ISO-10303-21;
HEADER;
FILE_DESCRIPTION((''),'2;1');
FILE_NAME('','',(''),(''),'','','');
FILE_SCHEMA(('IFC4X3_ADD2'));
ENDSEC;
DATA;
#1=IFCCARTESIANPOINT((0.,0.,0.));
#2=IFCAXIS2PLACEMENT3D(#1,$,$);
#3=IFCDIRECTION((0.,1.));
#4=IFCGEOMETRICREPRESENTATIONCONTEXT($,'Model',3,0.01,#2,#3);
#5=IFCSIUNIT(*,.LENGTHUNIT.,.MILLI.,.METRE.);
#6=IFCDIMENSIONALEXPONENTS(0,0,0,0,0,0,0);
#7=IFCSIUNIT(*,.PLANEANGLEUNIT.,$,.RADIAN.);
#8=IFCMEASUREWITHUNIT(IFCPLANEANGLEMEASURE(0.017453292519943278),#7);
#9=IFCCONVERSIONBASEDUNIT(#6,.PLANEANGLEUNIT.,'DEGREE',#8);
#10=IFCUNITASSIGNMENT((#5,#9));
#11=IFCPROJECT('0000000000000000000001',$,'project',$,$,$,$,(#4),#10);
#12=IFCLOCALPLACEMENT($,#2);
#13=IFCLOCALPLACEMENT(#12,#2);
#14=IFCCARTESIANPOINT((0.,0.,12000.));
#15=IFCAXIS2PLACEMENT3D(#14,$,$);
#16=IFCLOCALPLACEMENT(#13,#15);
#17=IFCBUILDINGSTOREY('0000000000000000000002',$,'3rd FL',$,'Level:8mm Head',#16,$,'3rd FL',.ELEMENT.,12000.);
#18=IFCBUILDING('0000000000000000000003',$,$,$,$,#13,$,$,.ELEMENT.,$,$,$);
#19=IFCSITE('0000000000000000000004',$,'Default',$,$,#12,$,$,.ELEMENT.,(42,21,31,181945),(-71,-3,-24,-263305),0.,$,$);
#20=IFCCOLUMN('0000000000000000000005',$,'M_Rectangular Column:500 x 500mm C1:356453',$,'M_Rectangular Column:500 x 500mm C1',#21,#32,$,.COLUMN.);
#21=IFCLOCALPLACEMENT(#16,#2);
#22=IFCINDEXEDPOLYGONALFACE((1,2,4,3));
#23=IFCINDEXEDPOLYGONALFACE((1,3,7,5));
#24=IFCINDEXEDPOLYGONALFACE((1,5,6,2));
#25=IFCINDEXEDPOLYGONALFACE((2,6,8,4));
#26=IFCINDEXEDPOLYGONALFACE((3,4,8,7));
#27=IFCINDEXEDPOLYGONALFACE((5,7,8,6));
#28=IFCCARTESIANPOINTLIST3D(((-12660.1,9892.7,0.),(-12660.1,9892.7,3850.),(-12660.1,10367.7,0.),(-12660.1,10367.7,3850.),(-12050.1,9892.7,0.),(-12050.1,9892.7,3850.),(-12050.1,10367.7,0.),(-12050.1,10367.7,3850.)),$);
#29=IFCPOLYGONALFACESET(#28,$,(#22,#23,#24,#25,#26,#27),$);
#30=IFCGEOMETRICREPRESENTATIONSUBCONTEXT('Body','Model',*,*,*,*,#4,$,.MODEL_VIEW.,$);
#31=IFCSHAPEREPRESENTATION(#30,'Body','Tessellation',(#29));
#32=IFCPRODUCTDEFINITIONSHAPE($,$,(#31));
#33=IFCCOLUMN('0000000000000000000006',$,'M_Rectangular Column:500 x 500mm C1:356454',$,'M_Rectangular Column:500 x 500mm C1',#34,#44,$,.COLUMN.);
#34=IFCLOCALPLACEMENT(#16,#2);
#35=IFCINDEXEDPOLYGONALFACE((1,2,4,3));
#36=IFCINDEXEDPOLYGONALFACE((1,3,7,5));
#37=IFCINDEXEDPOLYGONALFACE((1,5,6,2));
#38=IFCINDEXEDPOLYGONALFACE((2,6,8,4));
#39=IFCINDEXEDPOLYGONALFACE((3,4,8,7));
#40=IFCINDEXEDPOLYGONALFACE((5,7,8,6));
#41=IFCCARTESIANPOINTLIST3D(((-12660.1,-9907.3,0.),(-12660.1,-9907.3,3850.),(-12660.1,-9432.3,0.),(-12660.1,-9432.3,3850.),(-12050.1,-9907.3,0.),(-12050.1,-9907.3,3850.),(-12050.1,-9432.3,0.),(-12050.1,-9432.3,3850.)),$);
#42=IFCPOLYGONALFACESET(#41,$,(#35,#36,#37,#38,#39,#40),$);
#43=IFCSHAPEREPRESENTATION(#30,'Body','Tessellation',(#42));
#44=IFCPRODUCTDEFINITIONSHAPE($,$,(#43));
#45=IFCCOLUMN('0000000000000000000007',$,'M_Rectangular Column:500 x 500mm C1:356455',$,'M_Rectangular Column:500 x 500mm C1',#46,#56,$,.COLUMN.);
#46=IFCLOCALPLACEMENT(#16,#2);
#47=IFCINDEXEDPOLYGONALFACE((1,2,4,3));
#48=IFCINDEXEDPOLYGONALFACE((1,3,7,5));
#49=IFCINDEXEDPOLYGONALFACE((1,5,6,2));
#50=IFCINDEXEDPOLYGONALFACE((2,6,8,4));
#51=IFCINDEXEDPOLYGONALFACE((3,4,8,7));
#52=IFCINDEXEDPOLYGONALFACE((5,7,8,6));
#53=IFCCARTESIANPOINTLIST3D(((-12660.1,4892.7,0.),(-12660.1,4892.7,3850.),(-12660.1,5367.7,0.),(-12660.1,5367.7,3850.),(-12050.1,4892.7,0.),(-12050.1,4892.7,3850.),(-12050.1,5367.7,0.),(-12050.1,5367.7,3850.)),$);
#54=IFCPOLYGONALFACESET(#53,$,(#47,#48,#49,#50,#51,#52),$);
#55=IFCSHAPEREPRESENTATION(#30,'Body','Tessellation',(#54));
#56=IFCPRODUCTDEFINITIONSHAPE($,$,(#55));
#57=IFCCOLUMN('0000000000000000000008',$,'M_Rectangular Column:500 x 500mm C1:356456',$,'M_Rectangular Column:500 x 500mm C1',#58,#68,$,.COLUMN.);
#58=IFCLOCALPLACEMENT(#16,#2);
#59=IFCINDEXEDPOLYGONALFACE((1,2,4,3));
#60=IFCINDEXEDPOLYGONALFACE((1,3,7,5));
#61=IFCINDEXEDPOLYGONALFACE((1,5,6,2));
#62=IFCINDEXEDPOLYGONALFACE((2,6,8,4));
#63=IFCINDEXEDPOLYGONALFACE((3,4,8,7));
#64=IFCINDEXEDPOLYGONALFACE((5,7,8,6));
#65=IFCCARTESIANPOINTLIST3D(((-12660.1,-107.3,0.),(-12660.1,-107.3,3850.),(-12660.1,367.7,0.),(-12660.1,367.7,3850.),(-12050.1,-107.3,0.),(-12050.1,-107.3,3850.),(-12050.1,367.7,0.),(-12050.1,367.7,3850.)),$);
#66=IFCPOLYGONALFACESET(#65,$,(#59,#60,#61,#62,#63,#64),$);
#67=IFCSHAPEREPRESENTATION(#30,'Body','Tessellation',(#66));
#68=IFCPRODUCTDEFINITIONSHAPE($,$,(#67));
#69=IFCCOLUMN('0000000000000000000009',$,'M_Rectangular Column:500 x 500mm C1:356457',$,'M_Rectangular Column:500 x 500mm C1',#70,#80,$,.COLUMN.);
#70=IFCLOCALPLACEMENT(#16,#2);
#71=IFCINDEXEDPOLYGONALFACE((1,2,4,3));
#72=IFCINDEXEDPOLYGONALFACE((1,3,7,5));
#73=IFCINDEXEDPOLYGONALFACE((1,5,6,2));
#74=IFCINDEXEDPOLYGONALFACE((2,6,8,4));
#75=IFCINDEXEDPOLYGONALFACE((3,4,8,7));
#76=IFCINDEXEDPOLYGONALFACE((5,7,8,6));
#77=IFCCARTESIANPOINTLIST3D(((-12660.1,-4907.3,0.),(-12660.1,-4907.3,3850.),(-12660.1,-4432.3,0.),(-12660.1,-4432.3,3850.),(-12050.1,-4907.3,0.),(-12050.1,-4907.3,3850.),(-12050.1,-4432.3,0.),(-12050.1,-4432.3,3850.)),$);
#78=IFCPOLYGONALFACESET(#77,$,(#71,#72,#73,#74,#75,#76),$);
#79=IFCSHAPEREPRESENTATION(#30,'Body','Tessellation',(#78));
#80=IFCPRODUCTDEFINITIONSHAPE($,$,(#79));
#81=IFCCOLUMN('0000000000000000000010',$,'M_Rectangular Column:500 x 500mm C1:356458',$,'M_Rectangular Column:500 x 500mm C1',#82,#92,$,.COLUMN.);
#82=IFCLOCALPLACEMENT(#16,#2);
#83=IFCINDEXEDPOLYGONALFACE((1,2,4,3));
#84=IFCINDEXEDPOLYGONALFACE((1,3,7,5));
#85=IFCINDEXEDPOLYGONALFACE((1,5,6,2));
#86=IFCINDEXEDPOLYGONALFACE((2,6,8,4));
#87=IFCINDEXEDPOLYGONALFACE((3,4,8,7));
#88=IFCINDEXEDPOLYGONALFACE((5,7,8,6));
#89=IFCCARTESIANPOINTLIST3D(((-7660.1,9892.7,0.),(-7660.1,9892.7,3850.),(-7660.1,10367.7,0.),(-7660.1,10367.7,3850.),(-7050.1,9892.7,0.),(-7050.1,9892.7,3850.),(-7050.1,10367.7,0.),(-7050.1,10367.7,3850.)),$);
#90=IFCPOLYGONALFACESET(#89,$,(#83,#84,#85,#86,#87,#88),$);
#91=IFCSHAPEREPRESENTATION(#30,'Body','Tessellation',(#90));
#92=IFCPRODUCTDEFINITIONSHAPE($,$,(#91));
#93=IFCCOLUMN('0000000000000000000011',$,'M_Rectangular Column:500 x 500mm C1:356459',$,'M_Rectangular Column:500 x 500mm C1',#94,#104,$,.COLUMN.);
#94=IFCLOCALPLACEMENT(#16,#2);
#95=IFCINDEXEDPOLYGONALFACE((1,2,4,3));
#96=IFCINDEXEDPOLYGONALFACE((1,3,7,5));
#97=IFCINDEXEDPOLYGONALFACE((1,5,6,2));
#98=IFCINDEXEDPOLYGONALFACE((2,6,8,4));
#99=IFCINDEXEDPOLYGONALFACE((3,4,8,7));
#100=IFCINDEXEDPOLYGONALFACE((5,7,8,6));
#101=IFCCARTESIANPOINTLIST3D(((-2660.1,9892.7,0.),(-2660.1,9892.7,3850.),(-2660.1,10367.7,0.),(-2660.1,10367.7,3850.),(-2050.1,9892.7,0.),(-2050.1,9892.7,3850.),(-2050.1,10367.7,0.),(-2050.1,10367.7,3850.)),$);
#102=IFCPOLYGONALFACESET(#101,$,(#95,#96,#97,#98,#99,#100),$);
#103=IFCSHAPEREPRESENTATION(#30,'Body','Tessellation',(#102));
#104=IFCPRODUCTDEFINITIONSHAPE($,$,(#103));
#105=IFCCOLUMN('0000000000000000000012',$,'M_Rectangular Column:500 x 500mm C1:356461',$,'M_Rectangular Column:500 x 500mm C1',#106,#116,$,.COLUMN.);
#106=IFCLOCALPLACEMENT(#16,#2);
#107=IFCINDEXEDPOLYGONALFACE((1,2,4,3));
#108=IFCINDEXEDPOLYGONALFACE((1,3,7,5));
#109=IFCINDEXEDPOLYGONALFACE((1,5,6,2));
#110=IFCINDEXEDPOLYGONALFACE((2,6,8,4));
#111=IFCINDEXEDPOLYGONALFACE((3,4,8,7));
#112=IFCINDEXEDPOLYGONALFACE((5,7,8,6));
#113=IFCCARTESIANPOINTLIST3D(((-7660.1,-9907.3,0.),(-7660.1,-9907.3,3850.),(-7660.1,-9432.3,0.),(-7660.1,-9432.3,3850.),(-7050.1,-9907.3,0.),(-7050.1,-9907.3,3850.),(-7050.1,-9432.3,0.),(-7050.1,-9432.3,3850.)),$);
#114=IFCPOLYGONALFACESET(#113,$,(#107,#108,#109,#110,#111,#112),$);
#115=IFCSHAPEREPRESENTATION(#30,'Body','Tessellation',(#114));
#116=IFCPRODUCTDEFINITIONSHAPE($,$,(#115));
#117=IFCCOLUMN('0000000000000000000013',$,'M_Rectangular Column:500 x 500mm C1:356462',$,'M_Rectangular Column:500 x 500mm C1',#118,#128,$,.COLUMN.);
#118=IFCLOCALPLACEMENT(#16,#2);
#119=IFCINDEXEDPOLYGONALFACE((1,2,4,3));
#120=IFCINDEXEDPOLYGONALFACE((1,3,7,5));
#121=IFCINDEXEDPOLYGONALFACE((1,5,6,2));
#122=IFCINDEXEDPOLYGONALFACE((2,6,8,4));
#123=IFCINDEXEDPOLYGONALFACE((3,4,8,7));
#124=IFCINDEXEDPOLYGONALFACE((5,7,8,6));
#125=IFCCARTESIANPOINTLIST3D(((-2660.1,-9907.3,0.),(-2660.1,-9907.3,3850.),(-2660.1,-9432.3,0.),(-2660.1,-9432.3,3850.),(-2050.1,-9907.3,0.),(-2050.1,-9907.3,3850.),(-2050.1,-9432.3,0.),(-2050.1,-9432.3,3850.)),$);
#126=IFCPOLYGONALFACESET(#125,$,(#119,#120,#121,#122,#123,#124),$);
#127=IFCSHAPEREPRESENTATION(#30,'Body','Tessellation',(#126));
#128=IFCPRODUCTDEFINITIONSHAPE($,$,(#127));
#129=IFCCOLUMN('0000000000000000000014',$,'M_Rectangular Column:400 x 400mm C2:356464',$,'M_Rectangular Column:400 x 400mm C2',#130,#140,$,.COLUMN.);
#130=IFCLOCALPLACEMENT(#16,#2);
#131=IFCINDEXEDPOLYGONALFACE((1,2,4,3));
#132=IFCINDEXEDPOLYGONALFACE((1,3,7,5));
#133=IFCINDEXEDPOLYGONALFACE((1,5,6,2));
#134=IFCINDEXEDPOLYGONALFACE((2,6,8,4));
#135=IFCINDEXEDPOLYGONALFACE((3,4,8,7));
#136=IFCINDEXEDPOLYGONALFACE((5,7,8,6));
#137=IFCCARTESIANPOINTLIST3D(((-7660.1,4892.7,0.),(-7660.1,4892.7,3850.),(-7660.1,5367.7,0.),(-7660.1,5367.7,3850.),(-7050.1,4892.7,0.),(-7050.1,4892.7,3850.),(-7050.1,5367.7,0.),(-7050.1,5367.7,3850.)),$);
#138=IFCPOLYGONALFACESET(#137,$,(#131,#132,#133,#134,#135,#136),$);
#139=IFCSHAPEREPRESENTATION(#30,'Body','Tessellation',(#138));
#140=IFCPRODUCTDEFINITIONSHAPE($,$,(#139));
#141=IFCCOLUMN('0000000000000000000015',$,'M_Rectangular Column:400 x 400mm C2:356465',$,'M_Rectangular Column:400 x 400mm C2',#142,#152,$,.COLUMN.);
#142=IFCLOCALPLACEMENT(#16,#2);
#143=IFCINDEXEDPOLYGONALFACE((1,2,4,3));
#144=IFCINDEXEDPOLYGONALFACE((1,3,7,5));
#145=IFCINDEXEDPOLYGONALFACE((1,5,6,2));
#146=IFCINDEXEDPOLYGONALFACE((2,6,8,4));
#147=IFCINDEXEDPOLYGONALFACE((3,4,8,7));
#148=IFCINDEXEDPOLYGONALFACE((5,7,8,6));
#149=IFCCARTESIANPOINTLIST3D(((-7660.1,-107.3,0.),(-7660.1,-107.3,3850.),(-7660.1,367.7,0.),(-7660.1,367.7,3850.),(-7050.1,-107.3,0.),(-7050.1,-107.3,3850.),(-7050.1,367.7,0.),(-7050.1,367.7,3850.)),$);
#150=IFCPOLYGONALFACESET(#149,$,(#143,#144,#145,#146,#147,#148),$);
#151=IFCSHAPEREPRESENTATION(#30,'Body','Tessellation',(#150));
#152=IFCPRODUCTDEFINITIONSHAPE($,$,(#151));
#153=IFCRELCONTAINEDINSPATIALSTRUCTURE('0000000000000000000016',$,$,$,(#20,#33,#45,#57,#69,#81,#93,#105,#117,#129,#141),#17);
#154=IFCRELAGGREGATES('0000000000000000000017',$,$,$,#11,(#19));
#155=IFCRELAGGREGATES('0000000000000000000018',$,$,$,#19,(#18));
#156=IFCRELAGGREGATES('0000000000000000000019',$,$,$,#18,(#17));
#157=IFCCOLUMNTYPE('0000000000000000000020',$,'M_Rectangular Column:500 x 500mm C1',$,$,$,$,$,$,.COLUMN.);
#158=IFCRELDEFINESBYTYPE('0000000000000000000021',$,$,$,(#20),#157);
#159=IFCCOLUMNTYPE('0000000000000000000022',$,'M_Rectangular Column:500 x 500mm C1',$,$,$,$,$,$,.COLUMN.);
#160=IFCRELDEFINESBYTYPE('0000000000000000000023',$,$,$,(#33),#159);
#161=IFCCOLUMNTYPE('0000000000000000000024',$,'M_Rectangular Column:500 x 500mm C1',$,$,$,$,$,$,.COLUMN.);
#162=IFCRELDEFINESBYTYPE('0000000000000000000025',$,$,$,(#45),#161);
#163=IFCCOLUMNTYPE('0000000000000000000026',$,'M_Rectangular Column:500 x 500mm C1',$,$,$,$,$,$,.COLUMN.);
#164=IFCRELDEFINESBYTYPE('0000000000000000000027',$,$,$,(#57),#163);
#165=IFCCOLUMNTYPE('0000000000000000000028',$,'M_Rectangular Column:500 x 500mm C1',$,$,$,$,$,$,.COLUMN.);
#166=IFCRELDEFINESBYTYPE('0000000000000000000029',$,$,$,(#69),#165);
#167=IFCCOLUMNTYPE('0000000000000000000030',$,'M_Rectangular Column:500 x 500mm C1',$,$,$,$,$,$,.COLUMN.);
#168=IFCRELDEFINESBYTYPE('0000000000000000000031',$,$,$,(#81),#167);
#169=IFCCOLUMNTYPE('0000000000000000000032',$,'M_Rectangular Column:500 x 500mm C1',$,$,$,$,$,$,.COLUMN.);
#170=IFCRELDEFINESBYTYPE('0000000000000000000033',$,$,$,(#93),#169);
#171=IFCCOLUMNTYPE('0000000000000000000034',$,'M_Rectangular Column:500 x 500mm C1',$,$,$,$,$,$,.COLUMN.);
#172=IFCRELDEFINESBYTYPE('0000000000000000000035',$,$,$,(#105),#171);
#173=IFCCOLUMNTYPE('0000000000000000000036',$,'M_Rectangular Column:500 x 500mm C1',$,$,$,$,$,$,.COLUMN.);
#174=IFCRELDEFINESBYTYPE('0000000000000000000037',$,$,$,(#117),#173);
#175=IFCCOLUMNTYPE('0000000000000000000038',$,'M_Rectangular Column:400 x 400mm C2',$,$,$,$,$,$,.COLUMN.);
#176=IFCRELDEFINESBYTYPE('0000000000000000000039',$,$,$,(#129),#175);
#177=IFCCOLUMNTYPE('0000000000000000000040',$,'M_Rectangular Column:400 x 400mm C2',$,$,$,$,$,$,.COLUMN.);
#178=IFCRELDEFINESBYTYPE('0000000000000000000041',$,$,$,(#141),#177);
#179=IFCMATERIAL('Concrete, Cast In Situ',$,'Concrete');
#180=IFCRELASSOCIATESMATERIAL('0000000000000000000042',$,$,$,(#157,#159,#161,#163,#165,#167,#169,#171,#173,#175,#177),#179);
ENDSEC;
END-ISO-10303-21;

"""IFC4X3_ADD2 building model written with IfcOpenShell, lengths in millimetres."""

from ifc_helpers import new_model, entity, si_unit, converted_unit, direction, frame, frame_2d, origin, origin_2d_with_axis, place, context, subcontext, project, spatial, rectangle, extrude, source, transform, mapped, material, material_profile, profile_set, type_object, type_shapes, element, save


model = new_model("IFC4X3_ADD2")

# Units and contexts
model_context = context("Model", 3, precision=0.01, world=origin(), true_north=direction((0.0, 1.0)))
body_context = subcontext(model_context, "Body", "Model", "MODEL_VIEW")
ifc_project = project(units=[si_unit("LENGTHUNIT", "METRE", prefix="MILLI"), converted_unit("PLANEANGLEUNIT", "DEGREE", entity("IfcPlaneAngleMeasure", 0.017453292519943278), si_unit("PLANEANGLEUNIT", "RADIAN"), dimensions=[0, 0, 0, 0, 0, 0, 0])], contexts=[model_context])

# Site, building, storey
site_placement = place(None, origin())
site = spatial("IfcSite", under=ifc_project, at=site_placement, Name="Default", CompositionType="ELEMENT", RefLatitude=(42, 21, 31, 181945), RefLongitude=(-71, -3, -24, -263305), RefElevation=0.0)
building_placement = place(site_placement, origin())
building = spatial("IfcBuilding", under=site, at=building_placement, CompositionType="ELEMENT")
storey_placement = place(building_placement, frame((0.0, 0.0, 12000.0)))
storey = spatial("IfcBuildingStorey", under=building, at=storey_placement, Name="3rd FL", ObjectType="Level:8mm Head", LongName="3rd FL", CompositionType="ELEMENT", Elevation=12000.0)

# Columns
ifc_material_1 = material(Name="Concrete, Cast In Situ", Category="Concrete")
ifc_material_profile_1 = material_profile(ifc_material_1, rectangle(XDim=610.0, YDim=475.0, at=frame_2d((0.0, 0.0), x_axis=(1.0, 0.0))), Name="500 x 500mm C1")
ifc_profile_set_1 = profile_set([ifc_material_profile_1], Name="500 x 500mm C1")
column_type_1 = type_object("IfcColumnType", Name="M_Rectangular Column:500 x 500mm C1", PredefinedType="COLUMN", material=ifc_profile_set_1)
shared_shape_1 = source(origin(), body_context, "Body", "SweptSolid", [
    extrude(rectangle(XDim=610.0, YDim=475.0, at=frame_2d((0.0, 0.0), x_axis=(1.0, 0.0))), frame((-12355.1, 10130.2, 12000.0), z_axis=(0.0, 0.0, 1.0), x_axis=(-1.0, 0.0, 0.0)), (0.0, 0.0, 1.0), 3850.0),
])
type_shapes(column_type_1, [shared_shape_1])
column_1_placement = place(storey_placement, frame((0.0, 0.0, -12000.0)))
element("IfcColumn", 1, at=column_1_placement, inside=storey, type_object=column_type_1, Name="M_Rectangular Column:500 x 500mm C1:356453", ObjectType="M_Rectangular Column:500 x 500mm C1", PredefinedType="COLUMN", context=body_context, shape_type="MappedRepresentation", body=[
    mapped(shared_shape_1, transform((0.0, 0.0, 0.0), scale=1.0)),
])
column_type_2 = type_object("IfcColumnType", Name="M_Rectangular Column:500 x 500mm C1", PredefinedType="COLUMN", material=ifc_profile_set_1)
shared_shape_2 = source(origin(), body_context, "Body", "SweptSolid", [
    extrude(rectangle(XDim=610.0, YDim=475.0, at=frame_2d((0.0, 0.0), x_axis=(1.0, 0.0))), frame((-12355.1, -9669.8, 12000.0), z_axis=(0.0, 0.0, 1.0), x_axis=(-1.0, 0.0, 0.0)), (0.0, 0.0, 1.0), 3850.0),
])
type_shapes(column_type_2, [shared_shape_2])
column_2_placement = place(storey_placement, frame((0.0, 0.0, -12000.0)))
element("IfcColumn", 2, at=column_2_placement, inside=storey, type_object=column_type_2, Name="M_Rectangular Column:500 x 500mm C1:356454", ObjectType="M_Rectangular Column:500 x 500mm C1", PredefinedType="COLUMN", context=body_context, shape_type="MappedRepresentation", body=[
    mapped(shared_shape_2, transform((0.0, 0.0, 0.0), scale=1.0)),
])
column_type_3 = type_object("IfcColumnType", Name="M_Rectangular Column:500 x 500mm C1", PredefinedType="COLUMN", material=ifc_profile_set_1)
shared_shape_3 = source(origin(), body_context, "Body", "SweptSolid", [
    extrude(rectangle(XDim=610.0, YDim=475.0, at=frame_2d((0.0, 0.0), x_axis=(1.0, 0.0))), frame((-12355.1, 5130.2, 12000.0), z_axis=(0.0, 0.0, 1.0), x_axis=(-1.0, 0.0, 0.0)), (0.0, 0.0, 1.0), 3850.0),
])
type_shapes(column_type_3, [shared_shape_3])
column_3_placement = place(storey_placement, frame((0.0, 0.0, -12000.0)))
element("IfcColumn", 3, at=column_3_placement, inside=storey, type_object=column_type_3, Name="M_Rectangular Column:500 x 500mm C1:356455", ObjectType="M_Rectangular Column:500 x 500mm C1", PredefinedType="COLUMN", context=body_context, shape_type="MappedRepresentation", body=[
    mapped(shared_shape_3, transform((0.0, 0.0, 0.0), scale=1.0)),
])
column_type_4 = type_object("IfcColumnType", Name="M_Rectangular Column:500 x 500mm C1", PredefinedType="COLUMN", material=ifc_profile_set_1)
shared_shape_4 = source(origin(), body_context, "Body", "SweptSolid", [
    extrude(rectangle(XDim=610.0, YDim=475.0, at=origin_2d_with_axis()), frame((-12355.1, 130.2, 12000.0), z_axis=(0.0, 0.0, 1.0), x_axis=(-1.0, 0.0, 0.0)), (0.0, 0.0, 1.0), 3850.0),
])
type_shapes(column_type_4, [shared_shape_4])
column_4_placement = place(storey_placement, frame((0.0, 0.0, -12000.0)))
element("IfcColumn", 4, at=column_4_placement, inside=storey, type_object=column_type_4, Name="M_Rectangular Column:500 x 500mm C1:356456", ObjectType="M_Rectangular Column:500 x 500mm C1", PredefinedType="COLUMN", context=body_context, shape_type="MappedRepresentation", body=[
    mapped(shared_shape_4, transform((0.0, 0.0, 0.0), scale=1.0)),
])
column_type_5 = type_object("IfcColumnType", Name="M_Rectangular Column:500 x 500mm C1", PredefinedType="COLUMN", material=ifc_profile_set_1)
shared_shape_5 = source(origin(), body_context, "Body", "SweptSolid", [
    extrude(rectangle(XDim=610.0, YDim=475.0, at=frame_2d((0.0, 0.0), x_axis=(1.0, 0.0))), frame((-12355.1, -4669.8, 12000.0), z_axis=(0.0, 0.0, 1.0), x_axis=(-1.0, 0.0, 0.0)), (0.0, 0.0, 1.0), 3850.0),
])
type_shapes(column_type_5, [shared_shape_5])
column_5_placement = place(storey_placement, frame((0.0, 0.0, -12000.0)))
element("IfcColumn", 5, at=column_5_placement, inside=storey, type_object=column_type_5, Name="M_Rectangular Column:500 x 500mm C1:356457", ObjectType="M_Rectangular Column:500 x 500mm C1", PredefinedType="COLUMN", context=body_context, shape_type="MappedRepresentation", body=[
    mapped(shared_shape_5, transform((0.0, 0.0, 0.0), scale=1.0)),
])
column_type_6 = type_object("IfcColumnType", Name="M_Rectangular Column:500 x 500mm C1", PredefinedType="COLUMN", material=ifc_profile_set_1)
shared_shape_6 = source(origin(), body_context, "Body", "SweptSolid", [
    extrude(rectangle(XDim=610.0, YDim=475.0, at=frame_2d((0.0, 0.0), x_axis=(1.0, 0.0))), frame((-7355.1, 10130.2, 12000.0), z_axis=(0.0, 0.0, 1.0), x_axis=(-1.0, 0.0, 0.0)), (0.0, 0.0, 1.0), 3850.0),
])
type_shapes(column_type_6, [shared_shape_6])
column_6_placement = place(storey_placement, frame((0.0, 0.0, -12000.0)))
element("IfcColumn", 6, at=column_6_placement, inside=storey, type_object=column_type_6, Name="M_Rectangular Column:500 x 500mm C1:356458", ObjectType="M_Rectangular Column:500 x 500mm C1", PredefinedType="COLUMN", context=body_context, shape_type="MappedRepresentation", body=[
    mapped(shared_shape_6, transform((0.0, 0.0, 0.0), scale=1.0)),
])
column_type_7 = type_object("IfcColumnType", Name="M_Rectangular Column:500 x 500mm C1", PredefinedType="COLUMN", material=ifc_profile_set_1)
shared_shape_7 = source(origin(), body_context, "Body", "SweptSolid", [
    extrude(rectangle(XDim=610.0, YDim=475.0, at=frame_2d((0.0, 0.0), x_axis=(1.0, 0.0))), frame((-2355.1, 10130.2, 12000.0), z_axis=(0.0, 0.0, 1.0), x_axis=(-1.0, 0.0, 0.0)), (0.0, 0.0, 1.0), 3850.0),
])
type_shapes(column_type_7, [shared_shape_7])
column_7_placement = place(storey_placement, frame((0.0, 0.0, -12000.0)))
element("IfcColumn", 7, at=column_7_placement, inside=storey, type_object=column_type_7, Name="M_Rectangular Column:500 x 500mm C1:356459", ObjectType="M_Rectangular Column:500 x 500mm C1", PredefinedType="COLUMN", context=body_context, shape_type="MappedRepresentation", body=[
    mapped(shared_shape_7, transform((0.0, 0.0, 0.0), scale=1.0)),
])
column_type_8 = type_object("IfcColumnType", Name="M_Rectangular Column:500 x 500mm C1", PredefinedType="COLUMN", material=ifc_profile_set_1)
shared_shape_8 = source(origin(), body_context, "Body", "SweptSolid", [
    extrude(rectangle(XDim=610.0, YDim=475.0, at=origin_2d_with_axis()), frame((-7355.1, -9669.8, 12000.0), z_axis=(0.0, 0.0, 1.0), x_axis=(-1.0, 0.0, 0.0)), (0.0, 0.0, 1.0), 3850.0),
])
type_shapes(column_type_8, [shared_shape_8])
column_8_placement = place(storey_placement, frame((0.0, 0.0, -12000.0)))
element("IfcColumn", 8, at=column_8_placement, inside=storey, type_object=column_type_8, Name="M_Rectangular Column:500 x 500mm C1:356461", ObjectType="M_Rectangular Column:500 x 500mm C1", PredefinedType="COLUMN", context=body_context, shape_type="MappedRepresentation", body=[
    mapped(shared_shape_8, transform((0.0, 0.0, 0.0), scale=1.0)),
])
column_type_9 = type_object("IfcColumnType", Name="M_Rectangular Column:500 x 500mm C1", PredefinedType="COLUMN", material=ifc_profile_set_1)
shared_shape_9 = source(origin(), body_context, "Body", "SweptSolid", [
    extrude(rectangle(XDim=610.0, YDim=475.0, at=frame_2d((0.0, 0.0), x_axis=(1.0, 0.0))), frame((-2355.1, -9669.8, 12000.0), z_axis=(0.0, 0.0, 1.0), x_axis=(-1.0, 0.0, 0.0)), (0.0, 0.0, 1.0), 3850.0),
])
type_shapes(column_type_9, [shared_shape_9])
column_9_placement = place(storey_placement, frame((0.0, 0.0, -12000.0)))
element("IfcColumn", 9, at=column_9_placement, inside=storey, type_object=column_type_9, Name="M_Rectangular Column:500 x 500mm C1:356462", ObjectType="M_Rectangular Column:500 x 500mm C1", PredefinedType="COLUMN", context=body_context, shape_type="MappedRepresentation", body=[
    mapped(shared_shape_9, transform((0.0, 0.0, 0.0), scale=1.0)),
])
ifc_material_profile_2 = material_profile(ifc_material_1, rectangle(XDim=610.0, YDim=475.0, at=origin_2d_with_axis()), Name="400 x 400mm C2")
ifc_profile_set_2 = profile_set([ifc_material_profile_2], Name="400 x 400mm C2")
column_type_10 = type_object("IfcColumnType", Name="M_Rectangular Column:400 x 400mm C2", PredefinedType="COLUMN", material=ifc_profile_set_2)
shared_shape_10 = source(origin(), body_context, "Body", "SweptSolid", [
    extrude(rectangle(XDim=610.0, YDim=475.0, at=frame_2d((0.0, 0.0), x_axis=(1.0, 0.0))), frame((-7355.1, 5130.2, 12000.0), z_axis=(0.0, 0.0, 1.0), x_axis=(-1.0, 0.0, 0.0)), (0.0, 0.0, 1.0), 3850.0),
])
type_shapes(column_type_10, [shared_shape_10])
column_10_placement = place(storey_placement, frame((0.0, 0.0, -12000.0)))
element("IfcColumn", 10, at=column_10_placement, inside=storey, type_object=column_type_10, Name="M_Rectangular Column:400 x 400mm C2:356464", ObjectType="M_Rectangular Column:400 x 400mm C2", PredefinedType="COLUMN", context=body_context, shape_type="MappedRepresentation", body=[
    mapped(shared_shape_10, transform((0.0, 0.0, 0.0), scale=1.0)),
])
column_type_11 = type_object("IfcColumnType", Name="M_Rectangular Column:400 x 400mm C2", PredefinedType="COLUMN", material=ifc_profile_set_2)
shared_shape_11 = source(origin(), body_context, "Body", "SweptSolid", [
    extrude(rectangle(XDim=610.0, YDim=475.0, at=origin_2d_with_axis()), frame((-7355.1, 130.2, 12000.0), z_axis=(0.0, 0.0, 1.0), x_axis=(-1.0, 0.0, 0.0)), (0.0, 0.0, 1.0), 3850.0),
])
type_shapes(column_type_11, [shared_shape_11])
column_11_placement = place(storey_placement, frame((0.0, 0.0, -12000.0)))
element("IfcColumn", 11, at=column_11_placement, inside=storey, type_object=column_type_11, Name="M_Rectangular Column:400 x 400mm C2:356465", ObjectType="M_Rectangular Column:400 x 400mm C2", PredefinedType="COLUMN", context=body_context, shape_type="MappedRepresentation", body=[
    mapped(shared_shape_11, transform((0.0, 0.0, 0.0), scale=1.0)),
])

save(model, "model.ifc")
